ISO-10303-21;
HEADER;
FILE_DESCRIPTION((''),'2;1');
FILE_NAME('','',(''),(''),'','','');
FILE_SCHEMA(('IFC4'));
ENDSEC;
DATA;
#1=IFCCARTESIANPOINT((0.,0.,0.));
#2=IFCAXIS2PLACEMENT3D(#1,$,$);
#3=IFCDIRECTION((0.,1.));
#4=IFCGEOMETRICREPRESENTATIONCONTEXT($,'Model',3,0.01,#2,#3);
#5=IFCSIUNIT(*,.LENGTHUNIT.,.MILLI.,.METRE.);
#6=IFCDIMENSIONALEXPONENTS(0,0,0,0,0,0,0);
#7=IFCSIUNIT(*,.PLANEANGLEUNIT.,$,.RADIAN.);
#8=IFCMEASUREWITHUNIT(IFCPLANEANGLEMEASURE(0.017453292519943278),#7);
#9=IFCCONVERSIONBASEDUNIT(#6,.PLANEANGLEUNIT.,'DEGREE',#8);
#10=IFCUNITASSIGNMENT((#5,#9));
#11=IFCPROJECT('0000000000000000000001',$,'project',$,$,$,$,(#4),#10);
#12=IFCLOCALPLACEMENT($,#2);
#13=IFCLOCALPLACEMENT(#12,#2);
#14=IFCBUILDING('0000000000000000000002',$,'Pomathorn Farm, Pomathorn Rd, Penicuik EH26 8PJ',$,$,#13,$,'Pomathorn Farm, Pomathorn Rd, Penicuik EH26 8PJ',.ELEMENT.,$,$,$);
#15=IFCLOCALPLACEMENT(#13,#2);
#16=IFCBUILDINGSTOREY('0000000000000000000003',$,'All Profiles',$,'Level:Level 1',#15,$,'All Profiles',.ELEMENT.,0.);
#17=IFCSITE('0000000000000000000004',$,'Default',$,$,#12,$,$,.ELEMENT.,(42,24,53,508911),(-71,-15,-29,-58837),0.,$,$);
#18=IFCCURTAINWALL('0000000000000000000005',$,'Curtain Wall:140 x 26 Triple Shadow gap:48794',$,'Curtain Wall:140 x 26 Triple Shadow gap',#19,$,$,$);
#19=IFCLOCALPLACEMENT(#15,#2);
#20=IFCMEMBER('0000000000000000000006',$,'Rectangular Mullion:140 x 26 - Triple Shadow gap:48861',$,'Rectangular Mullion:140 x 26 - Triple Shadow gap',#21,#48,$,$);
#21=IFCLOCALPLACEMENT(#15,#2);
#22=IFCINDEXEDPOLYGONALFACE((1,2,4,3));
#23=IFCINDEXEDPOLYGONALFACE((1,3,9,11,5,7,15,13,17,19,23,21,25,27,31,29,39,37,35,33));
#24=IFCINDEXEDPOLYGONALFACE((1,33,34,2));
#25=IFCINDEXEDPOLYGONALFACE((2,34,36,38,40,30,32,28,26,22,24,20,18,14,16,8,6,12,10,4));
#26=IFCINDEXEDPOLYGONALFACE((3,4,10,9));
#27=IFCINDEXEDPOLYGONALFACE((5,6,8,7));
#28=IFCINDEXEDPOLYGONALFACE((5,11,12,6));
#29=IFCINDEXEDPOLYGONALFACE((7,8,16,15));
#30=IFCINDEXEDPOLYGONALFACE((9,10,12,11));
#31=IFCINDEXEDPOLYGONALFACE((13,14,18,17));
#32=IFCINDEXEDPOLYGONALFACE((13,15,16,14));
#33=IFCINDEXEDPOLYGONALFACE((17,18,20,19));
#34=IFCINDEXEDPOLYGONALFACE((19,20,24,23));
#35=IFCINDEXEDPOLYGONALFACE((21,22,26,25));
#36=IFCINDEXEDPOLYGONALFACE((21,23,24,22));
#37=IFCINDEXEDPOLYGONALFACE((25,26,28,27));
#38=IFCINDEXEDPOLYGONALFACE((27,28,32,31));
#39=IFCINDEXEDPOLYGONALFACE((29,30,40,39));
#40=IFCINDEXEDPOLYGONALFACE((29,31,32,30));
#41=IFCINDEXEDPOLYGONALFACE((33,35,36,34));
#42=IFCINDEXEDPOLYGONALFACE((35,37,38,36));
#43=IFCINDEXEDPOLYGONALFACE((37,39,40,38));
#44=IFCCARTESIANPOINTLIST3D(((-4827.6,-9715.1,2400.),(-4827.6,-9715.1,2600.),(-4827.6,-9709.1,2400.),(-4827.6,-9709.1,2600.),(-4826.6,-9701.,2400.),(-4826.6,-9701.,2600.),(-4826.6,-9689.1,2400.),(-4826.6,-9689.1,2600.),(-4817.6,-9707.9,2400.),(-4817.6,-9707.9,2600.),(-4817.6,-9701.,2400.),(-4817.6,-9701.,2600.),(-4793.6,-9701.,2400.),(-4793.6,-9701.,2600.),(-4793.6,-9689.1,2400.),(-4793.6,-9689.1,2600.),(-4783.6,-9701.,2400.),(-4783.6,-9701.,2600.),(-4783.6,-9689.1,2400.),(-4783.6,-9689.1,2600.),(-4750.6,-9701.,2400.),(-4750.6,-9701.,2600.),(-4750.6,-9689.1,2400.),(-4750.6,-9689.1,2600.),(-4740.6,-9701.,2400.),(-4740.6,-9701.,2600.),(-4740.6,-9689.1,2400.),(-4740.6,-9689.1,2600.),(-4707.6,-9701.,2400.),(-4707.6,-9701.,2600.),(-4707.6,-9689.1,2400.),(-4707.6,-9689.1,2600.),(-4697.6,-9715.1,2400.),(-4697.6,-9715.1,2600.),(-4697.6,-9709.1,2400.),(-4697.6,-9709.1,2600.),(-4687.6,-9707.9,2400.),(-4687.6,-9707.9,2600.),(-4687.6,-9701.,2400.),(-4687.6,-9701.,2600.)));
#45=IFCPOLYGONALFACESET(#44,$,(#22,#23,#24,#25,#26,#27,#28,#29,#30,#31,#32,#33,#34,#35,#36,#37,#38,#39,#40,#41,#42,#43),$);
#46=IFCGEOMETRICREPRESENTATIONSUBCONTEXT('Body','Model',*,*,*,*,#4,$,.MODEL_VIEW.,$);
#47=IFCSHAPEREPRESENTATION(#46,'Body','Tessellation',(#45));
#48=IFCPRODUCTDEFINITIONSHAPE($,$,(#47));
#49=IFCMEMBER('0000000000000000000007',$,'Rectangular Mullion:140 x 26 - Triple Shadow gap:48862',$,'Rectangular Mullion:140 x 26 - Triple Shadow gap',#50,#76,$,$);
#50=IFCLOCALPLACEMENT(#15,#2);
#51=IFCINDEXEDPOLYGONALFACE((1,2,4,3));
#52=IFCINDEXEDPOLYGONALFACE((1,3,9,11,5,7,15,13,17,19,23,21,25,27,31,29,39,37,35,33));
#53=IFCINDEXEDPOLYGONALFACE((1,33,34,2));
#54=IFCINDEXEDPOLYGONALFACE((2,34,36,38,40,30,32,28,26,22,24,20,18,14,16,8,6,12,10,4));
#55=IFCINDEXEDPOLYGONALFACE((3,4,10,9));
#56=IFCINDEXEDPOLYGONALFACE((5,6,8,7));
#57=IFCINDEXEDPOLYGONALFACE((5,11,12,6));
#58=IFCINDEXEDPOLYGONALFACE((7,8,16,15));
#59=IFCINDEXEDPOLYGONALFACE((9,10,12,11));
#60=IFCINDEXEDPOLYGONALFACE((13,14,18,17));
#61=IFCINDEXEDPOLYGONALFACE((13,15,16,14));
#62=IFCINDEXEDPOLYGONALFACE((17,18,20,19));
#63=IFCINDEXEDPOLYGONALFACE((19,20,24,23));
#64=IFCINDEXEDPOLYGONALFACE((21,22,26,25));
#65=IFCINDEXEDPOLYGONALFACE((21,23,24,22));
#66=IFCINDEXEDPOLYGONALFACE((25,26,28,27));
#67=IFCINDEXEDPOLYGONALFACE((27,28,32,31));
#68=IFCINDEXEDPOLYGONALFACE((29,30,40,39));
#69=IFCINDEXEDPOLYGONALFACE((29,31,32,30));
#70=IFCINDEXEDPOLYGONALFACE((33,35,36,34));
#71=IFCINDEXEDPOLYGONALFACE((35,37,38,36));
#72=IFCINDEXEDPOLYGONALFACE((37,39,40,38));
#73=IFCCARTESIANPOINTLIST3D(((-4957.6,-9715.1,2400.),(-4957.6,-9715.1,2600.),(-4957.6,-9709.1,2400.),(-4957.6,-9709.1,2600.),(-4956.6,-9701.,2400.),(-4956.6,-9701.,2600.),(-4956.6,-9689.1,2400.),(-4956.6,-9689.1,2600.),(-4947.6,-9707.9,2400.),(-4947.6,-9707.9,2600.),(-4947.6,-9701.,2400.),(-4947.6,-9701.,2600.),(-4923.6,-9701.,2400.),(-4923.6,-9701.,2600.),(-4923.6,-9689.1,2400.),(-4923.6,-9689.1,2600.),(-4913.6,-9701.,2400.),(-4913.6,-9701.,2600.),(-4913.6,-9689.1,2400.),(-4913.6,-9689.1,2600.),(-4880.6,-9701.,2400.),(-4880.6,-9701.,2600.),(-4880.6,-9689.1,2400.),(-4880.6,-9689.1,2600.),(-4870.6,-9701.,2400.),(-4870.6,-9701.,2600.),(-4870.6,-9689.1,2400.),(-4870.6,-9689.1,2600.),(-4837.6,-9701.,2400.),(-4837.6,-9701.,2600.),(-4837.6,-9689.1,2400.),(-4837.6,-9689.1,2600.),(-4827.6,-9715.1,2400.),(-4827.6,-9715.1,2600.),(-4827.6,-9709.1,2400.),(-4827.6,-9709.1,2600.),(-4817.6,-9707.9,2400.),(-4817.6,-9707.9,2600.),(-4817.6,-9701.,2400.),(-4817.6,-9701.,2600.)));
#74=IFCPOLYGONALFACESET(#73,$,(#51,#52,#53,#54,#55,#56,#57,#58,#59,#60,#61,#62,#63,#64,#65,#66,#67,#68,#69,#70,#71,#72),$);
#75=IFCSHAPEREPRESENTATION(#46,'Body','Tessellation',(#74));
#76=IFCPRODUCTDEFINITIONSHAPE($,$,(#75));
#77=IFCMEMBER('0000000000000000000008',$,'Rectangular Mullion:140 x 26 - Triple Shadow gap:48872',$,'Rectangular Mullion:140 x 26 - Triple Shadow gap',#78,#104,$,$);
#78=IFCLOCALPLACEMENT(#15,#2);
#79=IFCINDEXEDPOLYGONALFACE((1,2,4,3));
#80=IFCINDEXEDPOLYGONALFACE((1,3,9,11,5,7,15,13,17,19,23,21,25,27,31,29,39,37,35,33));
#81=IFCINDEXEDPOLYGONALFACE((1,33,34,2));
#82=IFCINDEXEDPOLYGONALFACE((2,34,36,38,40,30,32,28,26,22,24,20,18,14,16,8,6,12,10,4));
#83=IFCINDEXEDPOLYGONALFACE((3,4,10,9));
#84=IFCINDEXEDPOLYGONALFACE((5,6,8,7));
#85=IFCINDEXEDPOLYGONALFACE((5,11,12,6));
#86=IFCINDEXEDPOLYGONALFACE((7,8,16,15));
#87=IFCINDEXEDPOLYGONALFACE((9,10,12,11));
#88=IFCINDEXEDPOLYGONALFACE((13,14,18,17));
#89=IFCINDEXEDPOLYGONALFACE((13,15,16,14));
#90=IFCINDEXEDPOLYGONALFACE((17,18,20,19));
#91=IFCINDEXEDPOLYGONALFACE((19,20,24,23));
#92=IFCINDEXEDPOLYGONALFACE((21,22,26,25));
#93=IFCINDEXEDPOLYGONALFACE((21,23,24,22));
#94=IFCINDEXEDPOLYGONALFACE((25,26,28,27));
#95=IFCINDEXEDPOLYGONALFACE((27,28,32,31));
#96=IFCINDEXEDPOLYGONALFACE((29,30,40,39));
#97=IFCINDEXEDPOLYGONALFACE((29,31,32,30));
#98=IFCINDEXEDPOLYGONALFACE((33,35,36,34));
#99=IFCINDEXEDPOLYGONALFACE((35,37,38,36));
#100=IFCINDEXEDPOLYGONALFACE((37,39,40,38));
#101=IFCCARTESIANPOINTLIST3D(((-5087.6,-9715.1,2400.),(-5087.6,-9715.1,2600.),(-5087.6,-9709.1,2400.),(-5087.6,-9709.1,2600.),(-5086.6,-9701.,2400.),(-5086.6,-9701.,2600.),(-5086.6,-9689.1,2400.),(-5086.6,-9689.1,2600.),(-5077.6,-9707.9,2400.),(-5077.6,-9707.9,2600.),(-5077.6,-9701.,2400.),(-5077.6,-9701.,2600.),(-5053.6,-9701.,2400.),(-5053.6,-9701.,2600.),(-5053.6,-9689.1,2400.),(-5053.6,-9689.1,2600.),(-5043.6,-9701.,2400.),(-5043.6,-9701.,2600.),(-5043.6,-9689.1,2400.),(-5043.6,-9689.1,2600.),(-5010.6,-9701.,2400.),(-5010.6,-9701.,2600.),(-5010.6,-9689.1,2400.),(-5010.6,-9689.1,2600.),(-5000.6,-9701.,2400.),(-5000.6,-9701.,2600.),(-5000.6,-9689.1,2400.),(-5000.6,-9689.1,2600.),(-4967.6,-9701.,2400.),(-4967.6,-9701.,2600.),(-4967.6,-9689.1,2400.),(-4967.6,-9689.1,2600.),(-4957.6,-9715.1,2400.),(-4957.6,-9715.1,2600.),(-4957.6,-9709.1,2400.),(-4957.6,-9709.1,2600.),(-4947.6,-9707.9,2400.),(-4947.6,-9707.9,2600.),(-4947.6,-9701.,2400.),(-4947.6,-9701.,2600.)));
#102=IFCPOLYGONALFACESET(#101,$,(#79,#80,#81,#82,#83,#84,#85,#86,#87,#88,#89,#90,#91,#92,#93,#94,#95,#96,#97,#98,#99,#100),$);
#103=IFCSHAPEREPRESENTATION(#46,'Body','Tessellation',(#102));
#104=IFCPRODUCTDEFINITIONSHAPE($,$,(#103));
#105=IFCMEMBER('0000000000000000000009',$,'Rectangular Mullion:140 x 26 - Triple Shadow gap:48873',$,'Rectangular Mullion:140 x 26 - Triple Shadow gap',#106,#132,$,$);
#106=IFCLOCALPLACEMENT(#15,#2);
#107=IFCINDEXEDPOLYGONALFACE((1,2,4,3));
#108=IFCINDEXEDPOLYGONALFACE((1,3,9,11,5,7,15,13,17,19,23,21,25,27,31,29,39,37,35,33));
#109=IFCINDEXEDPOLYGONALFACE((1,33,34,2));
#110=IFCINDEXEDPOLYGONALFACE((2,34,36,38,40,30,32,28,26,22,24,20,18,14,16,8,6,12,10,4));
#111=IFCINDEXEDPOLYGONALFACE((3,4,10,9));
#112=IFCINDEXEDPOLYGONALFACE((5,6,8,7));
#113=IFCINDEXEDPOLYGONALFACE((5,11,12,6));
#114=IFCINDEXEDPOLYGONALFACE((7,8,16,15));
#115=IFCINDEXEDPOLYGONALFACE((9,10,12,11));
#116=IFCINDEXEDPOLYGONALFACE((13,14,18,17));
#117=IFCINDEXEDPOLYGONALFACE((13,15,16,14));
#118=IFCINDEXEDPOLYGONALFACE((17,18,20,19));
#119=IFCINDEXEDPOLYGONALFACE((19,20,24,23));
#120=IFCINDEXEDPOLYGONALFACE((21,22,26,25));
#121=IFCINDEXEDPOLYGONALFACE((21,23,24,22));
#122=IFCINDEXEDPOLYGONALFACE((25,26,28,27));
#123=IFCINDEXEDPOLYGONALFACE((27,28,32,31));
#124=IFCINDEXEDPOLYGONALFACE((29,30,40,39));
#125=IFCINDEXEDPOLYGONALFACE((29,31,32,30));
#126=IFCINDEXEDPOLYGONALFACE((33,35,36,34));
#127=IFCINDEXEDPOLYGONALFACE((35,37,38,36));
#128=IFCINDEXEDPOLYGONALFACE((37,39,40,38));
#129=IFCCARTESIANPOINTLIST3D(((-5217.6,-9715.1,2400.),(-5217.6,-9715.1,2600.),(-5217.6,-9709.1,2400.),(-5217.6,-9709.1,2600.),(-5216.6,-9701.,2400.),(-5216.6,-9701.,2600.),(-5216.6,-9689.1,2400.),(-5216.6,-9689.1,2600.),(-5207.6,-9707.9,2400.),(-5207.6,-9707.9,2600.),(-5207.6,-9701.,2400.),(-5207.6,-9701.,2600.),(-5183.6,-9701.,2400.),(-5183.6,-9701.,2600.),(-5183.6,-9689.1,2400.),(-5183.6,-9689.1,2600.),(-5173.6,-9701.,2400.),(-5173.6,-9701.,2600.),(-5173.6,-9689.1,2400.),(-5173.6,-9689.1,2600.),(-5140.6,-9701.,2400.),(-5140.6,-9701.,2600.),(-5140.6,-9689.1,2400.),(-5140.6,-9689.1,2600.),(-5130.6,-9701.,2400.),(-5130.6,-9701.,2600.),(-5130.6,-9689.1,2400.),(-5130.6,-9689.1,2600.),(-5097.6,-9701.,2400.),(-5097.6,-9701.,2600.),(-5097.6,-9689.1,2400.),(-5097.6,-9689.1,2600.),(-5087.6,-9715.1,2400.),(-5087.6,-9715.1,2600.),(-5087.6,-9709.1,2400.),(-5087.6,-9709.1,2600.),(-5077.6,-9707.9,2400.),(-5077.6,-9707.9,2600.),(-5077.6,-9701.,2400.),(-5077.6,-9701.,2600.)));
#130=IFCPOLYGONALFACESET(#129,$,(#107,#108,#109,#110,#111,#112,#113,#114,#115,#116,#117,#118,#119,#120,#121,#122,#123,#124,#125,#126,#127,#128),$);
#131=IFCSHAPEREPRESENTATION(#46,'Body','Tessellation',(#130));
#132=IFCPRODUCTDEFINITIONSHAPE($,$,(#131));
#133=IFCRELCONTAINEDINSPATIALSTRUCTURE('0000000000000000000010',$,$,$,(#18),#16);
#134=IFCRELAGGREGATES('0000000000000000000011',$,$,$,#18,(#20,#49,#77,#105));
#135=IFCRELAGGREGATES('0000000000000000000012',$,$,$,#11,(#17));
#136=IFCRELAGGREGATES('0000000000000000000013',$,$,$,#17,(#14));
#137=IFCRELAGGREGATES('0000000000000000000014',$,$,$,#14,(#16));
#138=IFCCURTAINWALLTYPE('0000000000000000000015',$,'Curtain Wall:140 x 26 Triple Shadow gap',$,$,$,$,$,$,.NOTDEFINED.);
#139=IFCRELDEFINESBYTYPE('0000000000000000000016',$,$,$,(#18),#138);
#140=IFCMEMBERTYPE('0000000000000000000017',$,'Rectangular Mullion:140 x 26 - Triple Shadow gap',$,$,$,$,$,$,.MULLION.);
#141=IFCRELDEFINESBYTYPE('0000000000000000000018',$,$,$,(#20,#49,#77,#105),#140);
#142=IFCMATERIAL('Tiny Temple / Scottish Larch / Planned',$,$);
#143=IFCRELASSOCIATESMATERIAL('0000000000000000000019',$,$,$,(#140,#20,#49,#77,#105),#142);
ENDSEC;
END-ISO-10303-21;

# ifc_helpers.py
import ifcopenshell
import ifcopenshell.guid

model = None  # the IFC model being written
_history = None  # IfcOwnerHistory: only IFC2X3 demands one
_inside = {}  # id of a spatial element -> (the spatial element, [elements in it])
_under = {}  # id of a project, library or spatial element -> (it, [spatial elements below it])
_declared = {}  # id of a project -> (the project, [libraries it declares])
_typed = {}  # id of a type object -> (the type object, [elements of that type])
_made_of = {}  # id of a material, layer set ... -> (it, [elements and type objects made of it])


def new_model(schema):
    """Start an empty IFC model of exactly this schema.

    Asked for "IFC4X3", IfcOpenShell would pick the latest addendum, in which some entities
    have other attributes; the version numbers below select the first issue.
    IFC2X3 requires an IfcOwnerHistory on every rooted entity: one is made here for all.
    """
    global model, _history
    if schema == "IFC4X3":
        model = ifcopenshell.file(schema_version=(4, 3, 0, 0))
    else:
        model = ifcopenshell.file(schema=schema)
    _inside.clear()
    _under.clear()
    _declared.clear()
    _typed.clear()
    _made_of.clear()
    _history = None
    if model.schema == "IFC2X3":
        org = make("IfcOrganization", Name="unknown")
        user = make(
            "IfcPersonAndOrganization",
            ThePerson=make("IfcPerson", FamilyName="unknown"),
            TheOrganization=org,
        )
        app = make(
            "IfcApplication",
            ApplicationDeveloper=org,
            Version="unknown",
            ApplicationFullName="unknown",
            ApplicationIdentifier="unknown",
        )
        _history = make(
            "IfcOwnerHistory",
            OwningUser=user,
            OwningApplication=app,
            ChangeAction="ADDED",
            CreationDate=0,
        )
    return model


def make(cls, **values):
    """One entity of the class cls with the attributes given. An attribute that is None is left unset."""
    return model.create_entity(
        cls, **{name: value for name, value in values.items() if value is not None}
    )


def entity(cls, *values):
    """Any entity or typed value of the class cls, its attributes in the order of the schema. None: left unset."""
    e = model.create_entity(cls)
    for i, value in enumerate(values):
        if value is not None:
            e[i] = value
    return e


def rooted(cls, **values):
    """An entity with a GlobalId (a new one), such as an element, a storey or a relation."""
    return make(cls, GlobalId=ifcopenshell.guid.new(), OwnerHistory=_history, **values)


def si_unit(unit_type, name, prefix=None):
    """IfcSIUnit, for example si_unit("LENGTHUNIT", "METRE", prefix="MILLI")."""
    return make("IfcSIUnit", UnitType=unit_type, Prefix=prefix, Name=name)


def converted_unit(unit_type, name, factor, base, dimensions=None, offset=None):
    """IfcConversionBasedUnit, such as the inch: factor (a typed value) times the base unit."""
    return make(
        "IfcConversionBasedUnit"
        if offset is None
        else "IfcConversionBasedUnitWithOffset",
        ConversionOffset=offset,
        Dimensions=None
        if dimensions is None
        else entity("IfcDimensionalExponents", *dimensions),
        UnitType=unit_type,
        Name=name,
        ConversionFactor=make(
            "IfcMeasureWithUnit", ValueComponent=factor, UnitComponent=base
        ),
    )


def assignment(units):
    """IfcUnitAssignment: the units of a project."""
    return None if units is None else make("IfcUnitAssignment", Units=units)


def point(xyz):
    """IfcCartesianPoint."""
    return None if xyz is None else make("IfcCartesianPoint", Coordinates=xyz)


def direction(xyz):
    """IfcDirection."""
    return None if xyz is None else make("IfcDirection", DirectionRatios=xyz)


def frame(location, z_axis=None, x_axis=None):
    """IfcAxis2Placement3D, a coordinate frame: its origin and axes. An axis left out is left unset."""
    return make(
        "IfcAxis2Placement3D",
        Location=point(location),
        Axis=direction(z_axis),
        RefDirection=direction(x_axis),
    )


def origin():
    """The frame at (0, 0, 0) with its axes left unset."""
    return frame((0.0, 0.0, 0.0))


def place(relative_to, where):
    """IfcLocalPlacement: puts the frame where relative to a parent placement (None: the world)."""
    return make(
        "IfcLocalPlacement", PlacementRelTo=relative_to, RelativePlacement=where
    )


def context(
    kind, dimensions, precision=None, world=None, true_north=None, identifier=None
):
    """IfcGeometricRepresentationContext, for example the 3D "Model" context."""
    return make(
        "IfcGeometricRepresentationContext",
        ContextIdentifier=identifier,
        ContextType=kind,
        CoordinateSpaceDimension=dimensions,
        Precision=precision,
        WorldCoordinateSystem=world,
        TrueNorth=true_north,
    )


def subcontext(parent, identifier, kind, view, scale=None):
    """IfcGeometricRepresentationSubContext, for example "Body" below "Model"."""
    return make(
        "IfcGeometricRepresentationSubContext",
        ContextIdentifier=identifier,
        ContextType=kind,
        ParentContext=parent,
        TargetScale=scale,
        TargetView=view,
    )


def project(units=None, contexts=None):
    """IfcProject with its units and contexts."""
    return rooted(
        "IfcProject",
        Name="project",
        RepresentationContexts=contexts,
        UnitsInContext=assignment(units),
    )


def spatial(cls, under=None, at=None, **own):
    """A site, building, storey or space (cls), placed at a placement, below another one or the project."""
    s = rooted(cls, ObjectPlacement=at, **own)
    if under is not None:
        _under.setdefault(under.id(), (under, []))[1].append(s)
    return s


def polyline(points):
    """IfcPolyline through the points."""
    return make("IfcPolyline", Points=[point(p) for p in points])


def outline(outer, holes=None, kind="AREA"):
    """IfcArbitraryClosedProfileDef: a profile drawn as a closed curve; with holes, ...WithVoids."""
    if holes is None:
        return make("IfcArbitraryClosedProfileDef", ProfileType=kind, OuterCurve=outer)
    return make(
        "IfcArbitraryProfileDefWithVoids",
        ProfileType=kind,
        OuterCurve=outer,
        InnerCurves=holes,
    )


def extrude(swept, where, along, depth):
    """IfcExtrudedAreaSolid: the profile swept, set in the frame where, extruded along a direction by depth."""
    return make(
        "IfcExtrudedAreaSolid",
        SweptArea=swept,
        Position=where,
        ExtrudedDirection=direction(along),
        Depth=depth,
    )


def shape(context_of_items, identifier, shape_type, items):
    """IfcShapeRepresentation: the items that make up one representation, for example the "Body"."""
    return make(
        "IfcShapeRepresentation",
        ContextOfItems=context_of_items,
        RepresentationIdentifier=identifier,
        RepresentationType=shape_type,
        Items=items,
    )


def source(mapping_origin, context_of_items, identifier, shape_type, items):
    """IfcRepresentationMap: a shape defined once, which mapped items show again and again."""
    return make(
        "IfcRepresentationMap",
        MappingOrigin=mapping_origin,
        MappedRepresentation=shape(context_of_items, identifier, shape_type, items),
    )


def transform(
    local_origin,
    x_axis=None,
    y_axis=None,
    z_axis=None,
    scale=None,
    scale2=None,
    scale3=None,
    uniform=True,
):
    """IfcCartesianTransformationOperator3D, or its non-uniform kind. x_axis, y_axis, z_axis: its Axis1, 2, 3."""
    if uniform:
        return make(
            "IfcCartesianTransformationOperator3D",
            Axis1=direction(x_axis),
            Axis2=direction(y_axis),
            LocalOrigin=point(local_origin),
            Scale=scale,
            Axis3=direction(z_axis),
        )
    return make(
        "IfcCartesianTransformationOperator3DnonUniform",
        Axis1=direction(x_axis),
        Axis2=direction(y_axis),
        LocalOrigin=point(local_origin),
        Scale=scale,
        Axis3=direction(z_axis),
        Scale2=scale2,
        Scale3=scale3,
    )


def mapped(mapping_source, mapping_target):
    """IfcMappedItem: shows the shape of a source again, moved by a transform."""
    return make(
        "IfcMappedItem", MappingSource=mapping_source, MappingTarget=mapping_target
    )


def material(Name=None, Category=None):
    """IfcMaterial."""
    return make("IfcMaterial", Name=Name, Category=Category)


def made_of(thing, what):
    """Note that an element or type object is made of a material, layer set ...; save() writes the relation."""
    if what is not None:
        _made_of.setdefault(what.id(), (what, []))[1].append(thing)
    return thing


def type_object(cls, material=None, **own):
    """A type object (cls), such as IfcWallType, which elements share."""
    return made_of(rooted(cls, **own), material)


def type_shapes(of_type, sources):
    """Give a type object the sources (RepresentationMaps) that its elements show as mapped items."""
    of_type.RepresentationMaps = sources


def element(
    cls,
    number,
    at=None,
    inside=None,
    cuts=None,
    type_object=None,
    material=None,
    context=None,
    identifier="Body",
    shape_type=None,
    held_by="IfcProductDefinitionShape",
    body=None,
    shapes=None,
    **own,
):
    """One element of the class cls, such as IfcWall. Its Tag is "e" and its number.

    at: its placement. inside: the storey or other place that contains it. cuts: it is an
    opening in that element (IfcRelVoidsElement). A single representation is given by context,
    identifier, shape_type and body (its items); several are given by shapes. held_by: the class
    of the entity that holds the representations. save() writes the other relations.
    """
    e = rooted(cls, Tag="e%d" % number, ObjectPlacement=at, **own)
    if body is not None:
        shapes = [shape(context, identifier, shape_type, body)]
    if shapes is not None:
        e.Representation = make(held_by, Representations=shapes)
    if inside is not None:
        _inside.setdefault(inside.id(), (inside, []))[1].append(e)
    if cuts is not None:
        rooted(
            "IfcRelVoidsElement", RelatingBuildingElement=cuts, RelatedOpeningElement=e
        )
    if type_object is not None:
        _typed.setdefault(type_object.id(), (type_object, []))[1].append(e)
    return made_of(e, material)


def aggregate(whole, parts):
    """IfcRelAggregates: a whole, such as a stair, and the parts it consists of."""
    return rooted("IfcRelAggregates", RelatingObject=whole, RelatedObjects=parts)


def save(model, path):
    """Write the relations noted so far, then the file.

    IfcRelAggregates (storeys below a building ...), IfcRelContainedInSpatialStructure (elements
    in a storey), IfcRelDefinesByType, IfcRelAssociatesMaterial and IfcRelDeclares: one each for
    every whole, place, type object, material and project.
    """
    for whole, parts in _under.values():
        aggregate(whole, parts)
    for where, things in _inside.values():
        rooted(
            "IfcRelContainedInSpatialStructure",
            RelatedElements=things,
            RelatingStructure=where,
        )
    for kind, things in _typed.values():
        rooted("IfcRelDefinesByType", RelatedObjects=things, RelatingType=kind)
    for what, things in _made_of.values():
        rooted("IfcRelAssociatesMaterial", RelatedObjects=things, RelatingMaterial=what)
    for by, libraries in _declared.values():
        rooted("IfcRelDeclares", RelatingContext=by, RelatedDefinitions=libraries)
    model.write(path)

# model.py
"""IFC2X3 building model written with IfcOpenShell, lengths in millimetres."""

from ifc_helpers import new_model, entity, si_unit, converted_unit, direction, frame, origin, place, context, subcontext, project, spatial, polyline, outline, extrude, source, transform, mapped, material, type_object, type_shapes, element, aggregate, save


model = new_model("IFC2X3")

# Units and contexts
model_context = context("Model", 3, precision=0.01, world=origin(), true_north=direction((0.0, 1.0)))
body_context = subcontext(model_context, "Body", "Model", "MODEL_VIEW")
ifc_project = project(units=[si_unit("LENGTHUNIT", "METRE", prefix="MILLI"), converted_unit("PLANEANGLEUNIT", "DEGREE", entity("IfcPlaneAngleMeasure", 0.017453292519943278), si_unit("PLANEANGLEUNIT", "RADIAN"), dimensions=[0, 0, 0, 0, 0, 0, 0])], contexts=[model_context])

# Site, building, storey
site_placement = place(None, origin())
site = spatial("IfcSite", under=ifc_project, at=site_placement, Name="Default", CompositionType="ELEMENT", RefLatitude=(42, 24, 53, 508911), RefLongitude=(-71, -15, -29, -58837), RefElevation=0.0)
building_placement = place(site_placement, origin())
building = spatial("IfcBuilding", under=site, at=building_placement, Name="Pomathorn Farm, Pomathorn Rd, Penicuik EH26 8PJ", LongName="Pomathorn Farm, Pomathorn Rd, Penicuik EH26 8PJ", CompositionType="ELEMENT")
storey_placement = place(building_placement, origin())
storey = spatial("IfcBuildingStorey", under=building, at=storey_placement, Name="All Profiles", ObjectType="Level:Level 1", LongName="All Profiles", CompositionType="ELEMENT", Elevation=0.0)

# Curtain wall, members
ifc_material = material(Name="Tiny Temple / Scottish Larch / Planned")
curtain_wall_type_1 = type_object("IfcCurtainWallType", Name="Curtain Wall:140 x 26 Triple Shadow gap", PredefinedType="NOTDEFINED")
curtain_wall_1_placement = place(storey_placement, origin())
curtain_wall_1 = element("IfcCurtainWall", 1, at=curtain_wall_1_placement, inside=storey, type_object=curtain_wall_type_1, Name="Curtain Wall:140 x 26 Triple Shadow gap:48794", ObjectType="Curtain Wall:140 x 26 Triple Shadow gap")
member_type_1 = type_object("IfcMemberType", Name="Rectangular Mullion:140 x 26 - Triple Shadow gap", PredefinedType="MULLION", material=ifc_material)
shared_shape_1 = source(origin(), body_context, "Body", "SweptSolid", [
    extrude(outline(polyline([(-64.9, -0.9), (-65.6, -6.8), (63.4, -22.7), (64.1, -16.7), (74.2, -16.7), (75.1, -9.8), (55.2, -7.4), (56.7, 4.3), (23.9, 8.4), (22.5, -3.4), (12.5, -2.2), (14.0, 9.6), (-18.8, 13.6), (-20.2, 1.9), (-30.1, 3.1), (-28.7, 14.8), (-61.5, 18.8), (-62.9, 7.1), (-54.0, 6.0), (-54.8, -0.9), (-64.9, -0.9)])), frame((-75.7, -14.8, -200.0), z_axis=(0.0, 0.0, -1.0), x_axis=(0.992546, -0.121869, 0.0)), (0.0, 0.0, -1.0), 200.0),
])
type_shapes(member_type_1, [shared_shape_1])
member_1_placement = place(curtain_wall_1_placement, frame((-4687.6, -9715.1, 2400.0), z_axis=(0.0, 0.0, -1.0), x_axis=(1.0, 0.0, 0.0)))
member_1 = element("IfcMember", 2, at=member_1_placement, type_object=member_type_1, material=ifc_material, Name="Rectangular Mullion:140 x 26 - Triple Shadow gap:48861", ObjectType="Rectangular Mullion:140 x 26 - Triple Shadow gap", context=body_context, shape_type="MappedRepresentation", body=[
    mapped(shared_shape_1, transform((0.0, 0.0, 0.0), scale=1.0)),
])
member_2_placement = place(curtain_wall_1_placement, frame((-4817.6, -9715.1, 2400.0), z_axis=(0.0, 0.0, -1.0), x_axis=(1.0, 0.0, 0.0)))
member_2 = element("IfcMember", 3, at=member_2_placement, type_object=member_type_1, material=ifc_material, Name="Rectangular Mullion:140 x 26 - Triple Shadow gap:48862", ObjectType="Rectangular Mullion:140 x 26 - Triple Shadow gap", context=body_context, shape_type="MappedRepresentation", body=[
    mapped(shared_shape_1, transform((0.0, 0.0, 0.0), scale=1.0)),
])
member_3_placement = place(curtain_wall_1_placement, frame((-4947.6, -9715.1, 2400.0), z_axis=(0.0, 0.0, -1.0), x_axis=(1.0, 0.0, 0.0)))
member_3 = element("IfcMember", 4, at=member_3_placement, type_object=member_type_1, material=ifc_material, Name="Rectangular Mullion:140 x 26 - Triple Shadow gap:48872", ObjectType="Rectangular Mullion:140 x 26 - Triple Shadow gap", context=body_context, shape_type="MappedRepresentation", body=[
    mapped(shared_shape_1, transform((0.0, 0.0, 0.0), scale=1.0)),
])
member_4_placement = place(curtain_wall_1_placement, frame((-5077.6, -9715.1, 2400.0), z_axis=(0.0, 0.0, -1.0), x_axis=(1.0, 0.0, 0.0)))
member_4 = element("IfcMember", 5, at=member_4_placement, type_object=member_type_1, material=ifc_material, Name="Rectangular Mullion:140 x 26 - Triple Shadow gap:48873", ObjectType="Rectangular Mullion:140 x 26 - Triple Shadow gap", context=body_context, shape_type="MappedRepresentation", body=[
    mapped(shared_shape_1, transform((0.0, 0.0, 0.0), scale=1.0)),
])
aggregate(curtain_wall_1, [member_1, member_2, member_3, member_4])

save(model, "model.ifc")
